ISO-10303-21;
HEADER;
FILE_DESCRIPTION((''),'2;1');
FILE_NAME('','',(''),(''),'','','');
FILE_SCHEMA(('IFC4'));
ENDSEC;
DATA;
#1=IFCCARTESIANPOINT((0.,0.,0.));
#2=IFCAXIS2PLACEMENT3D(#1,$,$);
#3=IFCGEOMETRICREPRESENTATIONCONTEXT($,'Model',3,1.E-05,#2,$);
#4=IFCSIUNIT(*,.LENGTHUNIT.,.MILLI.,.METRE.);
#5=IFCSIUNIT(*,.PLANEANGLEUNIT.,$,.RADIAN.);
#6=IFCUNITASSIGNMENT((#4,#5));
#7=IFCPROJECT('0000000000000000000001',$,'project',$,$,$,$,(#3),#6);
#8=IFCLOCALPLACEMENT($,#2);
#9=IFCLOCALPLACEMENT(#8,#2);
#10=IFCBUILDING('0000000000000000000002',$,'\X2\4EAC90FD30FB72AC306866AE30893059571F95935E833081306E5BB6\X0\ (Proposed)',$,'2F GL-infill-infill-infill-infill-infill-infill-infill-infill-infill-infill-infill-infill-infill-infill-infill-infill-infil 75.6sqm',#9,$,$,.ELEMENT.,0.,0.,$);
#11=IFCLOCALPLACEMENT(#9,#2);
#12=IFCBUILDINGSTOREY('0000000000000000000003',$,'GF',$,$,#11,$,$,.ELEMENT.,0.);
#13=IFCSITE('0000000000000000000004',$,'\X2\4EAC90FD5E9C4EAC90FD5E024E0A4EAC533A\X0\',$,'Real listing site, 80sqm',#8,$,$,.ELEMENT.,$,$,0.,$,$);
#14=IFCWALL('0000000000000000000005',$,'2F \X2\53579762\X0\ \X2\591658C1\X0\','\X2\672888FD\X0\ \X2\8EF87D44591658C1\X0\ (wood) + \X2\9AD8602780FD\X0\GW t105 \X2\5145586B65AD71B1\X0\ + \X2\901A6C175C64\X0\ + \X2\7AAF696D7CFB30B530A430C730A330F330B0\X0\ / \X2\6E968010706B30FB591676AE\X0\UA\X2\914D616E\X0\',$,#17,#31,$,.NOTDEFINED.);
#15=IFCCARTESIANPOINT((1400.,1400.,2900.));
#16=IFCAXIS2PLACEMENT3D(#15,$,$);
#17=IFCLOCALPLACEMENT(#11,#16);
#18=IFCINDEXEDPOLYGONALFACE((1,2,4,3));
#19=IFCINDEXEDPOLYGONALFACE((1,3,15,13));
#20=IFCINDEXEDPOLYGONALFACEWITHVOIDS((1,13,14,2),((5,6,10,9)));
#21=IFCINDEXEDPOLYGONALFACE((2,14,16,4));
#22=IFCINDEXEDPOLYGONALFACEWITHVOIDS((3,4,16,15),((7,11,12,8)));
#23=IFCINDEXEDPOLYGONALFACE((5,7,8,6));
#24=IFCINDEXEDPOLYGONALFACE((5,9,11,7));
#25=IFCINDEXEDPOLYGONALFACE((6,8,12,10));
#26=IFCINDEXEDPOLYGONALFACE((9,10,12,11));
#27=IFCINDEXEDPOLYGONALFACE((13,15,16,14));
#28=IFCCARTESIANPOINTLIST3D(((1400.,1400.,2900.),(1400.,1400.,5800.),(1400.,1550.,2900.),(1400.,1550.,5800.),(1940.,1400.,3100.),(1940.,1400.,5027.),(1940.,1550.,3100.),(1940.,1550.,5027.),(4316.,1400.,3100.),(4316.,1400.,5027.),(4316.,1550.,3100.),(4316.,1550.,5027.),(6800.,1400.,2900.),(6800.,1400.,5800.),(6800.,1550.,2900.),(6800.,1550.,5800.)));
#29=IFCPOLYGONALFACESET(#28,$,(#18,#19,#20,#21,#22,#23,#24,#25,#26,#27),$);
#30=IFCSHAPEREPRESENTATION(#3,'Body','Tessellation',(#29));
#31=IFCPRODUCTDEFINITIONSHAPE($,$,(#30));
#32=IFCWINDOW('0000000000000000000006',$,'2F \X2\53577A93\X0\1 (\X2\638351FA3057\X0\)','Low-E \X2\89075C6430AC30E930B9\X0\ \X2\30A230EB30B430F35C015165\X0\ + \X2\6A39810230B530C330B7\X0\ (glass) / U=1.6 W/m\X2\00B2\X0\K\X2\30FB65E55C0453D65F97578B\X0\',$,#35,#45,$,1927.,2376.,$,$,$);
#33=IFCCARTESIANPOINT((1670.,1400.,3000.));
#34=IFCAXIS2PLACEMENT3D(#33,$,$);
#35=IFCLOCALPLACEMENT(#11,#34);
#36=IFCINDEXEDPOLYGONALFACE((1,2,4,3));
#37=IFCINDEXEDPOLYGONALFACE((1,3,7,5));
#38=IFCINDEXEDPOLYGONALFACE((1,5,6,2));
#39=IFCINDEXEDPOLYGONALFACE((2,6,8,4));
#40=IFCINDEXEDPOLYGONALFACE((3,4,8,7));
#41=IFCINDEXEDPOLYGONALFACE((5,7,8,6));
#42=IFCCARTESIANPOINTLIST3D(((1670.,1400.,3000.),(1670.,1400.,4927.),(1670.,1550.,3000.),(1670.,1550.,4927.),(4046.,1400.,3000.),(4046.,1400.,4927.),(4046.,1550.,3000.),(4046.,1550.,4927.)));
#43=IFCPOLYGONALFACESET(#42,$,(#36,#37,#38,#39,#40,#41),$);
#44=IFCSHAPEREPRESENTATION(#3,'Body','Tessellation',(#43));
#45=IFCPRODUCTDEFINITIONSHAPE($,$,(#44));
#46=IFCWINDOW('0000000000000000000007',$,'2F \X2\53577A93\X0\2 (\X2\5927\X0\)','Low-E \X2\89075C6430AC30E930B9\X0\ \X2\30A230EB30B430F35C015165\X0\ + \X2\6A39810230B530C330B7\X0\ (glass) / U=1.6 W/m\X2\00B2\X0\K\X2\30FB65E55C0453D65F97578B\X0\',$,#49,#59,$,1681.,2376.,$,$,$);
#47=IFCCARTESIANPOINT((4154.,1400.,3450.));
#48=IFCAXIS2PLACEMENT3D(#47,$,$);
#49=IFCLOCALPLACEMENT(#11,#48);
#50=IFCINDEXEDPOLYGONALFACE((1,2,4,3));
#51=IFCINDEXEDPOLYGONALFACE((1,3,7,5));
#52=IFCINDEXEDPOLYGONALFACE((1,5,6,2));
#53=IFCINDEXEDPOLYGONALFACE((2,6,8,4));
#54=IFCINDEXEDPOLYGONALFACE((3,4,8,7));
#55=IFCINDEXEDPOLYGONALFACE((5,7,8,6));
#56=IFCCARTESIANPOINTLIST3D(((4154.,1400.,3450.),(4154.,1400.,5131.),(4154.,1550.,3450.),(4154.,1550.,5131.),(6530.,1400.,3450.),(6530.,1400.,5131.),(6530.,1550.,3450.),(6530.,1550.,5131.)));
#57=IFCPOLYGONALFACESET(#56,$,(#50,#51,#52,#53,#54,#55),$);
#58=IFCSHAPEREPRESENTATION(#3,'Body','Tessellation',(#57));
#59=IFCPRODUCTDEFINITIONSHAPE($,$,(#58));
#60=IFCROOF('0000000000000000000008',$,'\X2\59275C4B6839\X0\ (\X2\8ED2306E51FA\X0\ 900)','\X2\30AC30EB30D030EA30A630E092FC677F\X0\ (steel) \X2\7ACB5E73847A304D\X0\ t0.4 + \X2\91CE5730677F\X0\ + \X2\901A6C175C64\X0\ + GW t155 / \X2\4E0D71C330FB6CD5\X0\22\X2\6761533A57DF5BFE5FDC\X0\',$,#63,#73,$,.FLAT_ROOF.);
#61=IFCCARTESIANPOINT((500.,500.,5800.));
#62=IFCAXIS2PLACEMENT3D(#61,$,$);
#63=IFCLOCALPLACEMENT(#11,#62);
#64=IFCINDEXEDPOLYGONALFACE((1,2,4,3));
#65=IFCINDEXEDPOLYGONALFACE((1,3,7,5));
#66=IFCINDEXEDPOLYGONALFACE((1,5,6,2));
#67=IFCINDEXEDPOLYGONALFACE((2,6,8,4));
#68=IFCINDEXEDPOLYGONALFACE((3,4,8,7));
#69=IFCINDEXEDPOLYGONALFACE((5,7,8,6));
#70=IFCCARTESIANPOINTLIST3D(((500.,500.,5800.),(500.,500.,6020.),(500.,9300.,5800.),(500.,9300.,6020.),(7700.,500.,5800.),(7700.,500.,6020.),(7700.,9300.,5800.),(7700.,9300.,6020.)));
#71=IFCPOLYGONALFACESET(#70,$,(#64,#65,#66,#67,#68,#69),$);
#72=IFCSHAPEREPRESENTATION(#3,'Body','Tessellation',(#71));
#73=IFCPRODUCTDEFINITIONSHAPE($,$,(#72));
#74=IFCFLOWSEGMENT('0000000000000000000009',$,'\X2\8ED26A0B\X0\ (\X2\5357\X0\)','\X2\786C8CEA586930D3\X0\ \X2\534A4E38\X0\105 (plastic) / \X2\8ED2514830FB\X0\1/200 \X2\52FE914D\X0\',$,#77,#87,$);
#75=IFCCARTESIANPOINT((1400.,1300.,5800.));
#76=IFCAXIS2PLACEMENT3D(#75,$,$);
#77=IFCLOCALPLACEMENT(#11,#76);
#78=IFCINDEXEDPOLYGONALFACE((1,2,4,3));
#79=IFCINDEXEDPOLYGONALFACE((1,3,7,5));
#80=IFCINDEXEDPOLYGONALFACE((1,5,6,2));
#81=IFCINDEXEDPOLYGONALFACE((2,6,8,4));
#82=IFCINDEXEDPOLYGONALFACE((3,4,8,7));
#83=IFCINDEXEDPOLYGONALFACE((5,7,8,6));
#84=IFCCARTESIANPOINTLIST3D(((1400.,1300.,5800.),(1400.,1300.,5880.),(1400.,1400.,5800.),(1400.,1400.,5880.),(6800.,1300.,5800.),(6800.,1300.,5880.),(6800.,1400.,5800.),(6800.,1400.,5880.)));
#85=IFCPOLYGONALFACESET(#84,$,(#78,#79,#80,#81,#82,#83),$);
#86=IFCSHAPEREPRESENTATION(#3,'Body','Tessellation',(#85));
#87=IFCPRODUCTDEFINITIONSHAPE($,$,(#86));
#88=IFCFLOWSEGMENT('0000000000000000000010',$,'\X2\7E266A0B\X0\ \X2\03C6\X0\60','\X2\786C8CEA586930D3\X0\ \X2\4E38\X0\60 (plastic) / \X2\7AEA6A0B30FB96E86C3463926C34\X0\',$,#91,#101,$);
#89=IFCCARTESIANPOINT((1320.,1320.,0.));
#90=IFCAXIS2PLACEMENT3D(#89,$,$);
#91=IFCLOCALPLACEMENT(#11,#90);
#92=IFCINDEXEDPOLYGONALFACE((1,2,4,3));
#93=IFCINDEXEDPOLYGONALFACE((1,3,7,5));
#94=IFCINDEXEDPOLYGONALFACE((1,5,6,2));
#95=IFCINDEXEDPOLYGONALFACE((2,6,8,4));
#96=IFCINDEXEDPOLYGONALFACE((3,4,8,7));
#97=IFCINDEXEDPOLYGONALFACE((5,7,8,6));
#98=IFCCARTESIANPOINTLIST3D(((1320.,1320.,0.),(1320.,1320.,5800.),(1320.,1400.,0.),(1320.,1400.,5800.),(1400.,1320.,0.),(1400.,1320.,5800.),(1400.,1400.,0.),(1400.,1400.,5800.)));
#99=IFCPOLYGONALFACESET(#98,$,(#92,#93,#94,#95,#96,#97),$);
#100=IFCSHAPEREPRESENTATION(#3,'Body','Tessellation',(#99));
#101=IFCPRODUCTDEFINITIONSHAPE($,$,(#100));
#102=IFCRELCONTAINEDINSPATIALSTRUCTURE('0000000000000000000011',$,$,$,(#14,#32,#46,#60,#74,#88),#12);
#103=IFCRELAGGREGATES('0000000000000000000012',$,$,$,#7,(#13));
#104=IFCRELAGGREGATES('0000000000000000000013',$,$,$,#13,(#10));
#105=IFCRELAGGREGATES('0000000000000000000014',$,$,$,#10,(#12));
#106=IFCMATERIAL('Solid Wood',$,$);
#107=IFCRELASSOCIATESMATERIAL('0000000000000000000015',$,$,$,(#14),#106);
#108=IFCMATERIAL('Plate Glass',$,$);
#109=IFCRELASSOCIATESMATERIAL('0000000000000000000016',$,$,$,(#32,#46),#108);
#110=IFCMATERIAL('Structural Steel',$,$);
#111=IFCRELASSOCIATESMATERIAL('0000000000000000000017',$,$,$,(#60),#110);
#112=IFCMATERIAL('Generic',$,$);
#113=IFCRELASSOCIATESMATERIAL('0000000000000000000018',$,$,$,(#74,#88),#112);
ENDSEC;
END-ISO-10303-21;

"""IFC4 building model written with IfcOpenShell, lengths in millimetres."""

from ifc_helpers import new_model, si_unit, frame, frame_2d, origin, place, context, project, spatial, rectangle, extrude, material, element, fill, save


model = new_model("IFC4")

# Units and contexts
model_context = context("Model", 3, precision=1e-05, world=origin())
ifc_project = project(units=[si_unit("LENGTHUNIT", "METRE", prefix="MILLI"), si_unit("PLANEANGLEUNIT", "RADIAN")], contexts=[model_context])

# Site, building, storey
site_placement = place(None, origin())
site = spatial("IfcSite", under=ifc_project, at=site_placement, Name="京都府京都市上京区", ObjectType="Real listing site, 80sqm", CompositionType="ELEMENT", RefElevation=0.0)
building_placement = place(site_placement, origin())
building = spatial("IfcBuilding", under=site, at=building_placement, Name="京都・犬と暮らす土間広めの家 (Proposed)", ObjectType="2F GL-infill-infill-infill-infill-infill-infill-infill-infill-infill-infill-infill-infill-infill-infill-infill-infill-infil 75.6sqm", CompositionType="ELEMENT", ElevationOfRefHeight=0.0, ElevationOfTerrain=0.0)
storey_placement = place(building_placement, origin())
storey = spatial("IfcBuildingStorey", under=building, at=storey_placement, Name="GF", CompositionType="ELEMENT", Elevation=0.0)

# Shared definitions
ifc_material_1 = material(Name="Solid Wood")

# Shared definitions
ifc_material_2 = material(Name="Plate Glass")

# Wall, openings, windows
wall_1_placement = place(storey_placement, frame((1400.0, 1400.0, 2900.0)))
wall_1 = element("IfcWall", 1, at=wall_1_placement, inside=storey, material=ifc_material_1, Name="2F 南面 外壁", Description="木製 軸組外壁 (wood) + 高性能GW t105 充填断熱 + 通気層 + 窯業系サイディング / 準耐火・外皮UA配慮", PredefinedType="NOTDEFINED", context=model_context, shape_type="SweptSolid", body=[
    extrude(rectangle(XDim=5400.0, YDim=150.0, at=frame_2d((2700.0, 75.0))), frame((1400.0, 1400.0, 2900.0)), (0.0, 0.0, 1.0), 2900.0),
])
opening_1_placement = place(storey_placement, frame((1670.0, 1400.0, 3000.0)))
opening_1 = element("IfcOpeningElement", 2, at=opening_1_placement, cuts=wall_1, PredefinedType="NOTDEFINED", context=model_context, shape_type="SweptSolid", body=[
    extrude(rectangle(XDim=2376.0, YDim=150.0, at=frame_2d((1188.0, 75.0))), frame((1670.0, 1400.0, 3000.0)), (0.0, 0.0, 1.0), 1927.0),
])
opening_2_placement = place(storey_placement, frame((4154.0, 1400.0, 3450.0)))
opening_2 = element("IfcOpeningElement", 3, at=opening_2_placement, cuts=wall_1, PredefinedType="NOTDEFINED", context=model_context, shape_type="SweptSolid", body=[
    extrude(rectangle(XDim=2376.0, YDim=150.0, at=frame_2d((1188.0, 75.0))), frame((4154.0, 1400.0, 3450.0)), (0.0, 0.0, 1.0), 1681.0),
])
window_1_placement = place(storey_placement, frame((1670.0, 1400.0, 3000.0)))
window_1 = element("IfcWindow", 4, at=window_1_placement, inside=storey, material=ifc_material_2, Name="2F 南窓1 (掃出し)", Description="Low-E 複層ガラス アルゴン封入 + 樹脂サッシ (glass) / U=1.6 W/m²K・日射取得型", OverallHeight=1927.0, OverallWidth=2376.0, context=model_context, shape_type="SweptSolid", body=[
    extrude(rectangle(XDim=2376.0, YDim=150.0, at=frame_2d((1188.0, 75.0))), frame((1670.0, 1400.0, 3000.0)), (0.0, 0.0, 1.0), 1927.0),
])
fill(opening_1, window_1)
window_2_placement = place(storey_placement, frame((4154.0, 1400.0, 3450.0)))
window_2 = element("IfcWindow", 5, at=window_2_placement, inside=storey, material=ifc_material_2, Name="2F 南窓2 (大)", Description="Low-E 複層ガラス アルゴン封入 + 樹脂サッシ (glass) / U=1.6 W/m²K・日射取得型", OverallHeight=1681.0, OverallWidth=2376.0, context=model_context, shape_type="SweptSolid", body=[
    extrude(rectangle(XDim=2376.0, YDim=150.0, at=frame_2d((1188.0, 75.0))), frame((4154.0, 1400.0, 3450.0)), (0.0, 0.0, 1.0), 1681.0),
])
fill(opening_2, window_2)

# Roof
ifc_material_3 = material(Name="Structural Steel")
roof_placement = place(storey_placement, frame((500.0, 500.0, 5800.0)))
element("IfcRoof", 6, at=roof_placement, inside=storey, material=ifc_material_3, Name="大屋根 (軒の出 900)", Description="ガルバリウム鋼板 (steel) 立平葺き t0.4 + 野地板 + 通気層 + GW t155 / 不燃・法22条区域対応", PredefinedType="FLAT_ROOF", context=model_context, shape_type="SweptSolid", body=[
    extrude(rectangle(XDim=7200.0, YDim=8800.0, at=frame_2d((3600.0, 4400.0))), frame((500.0, 500.0, 5800.0)), (0.0, 0.0, 1.0), 220.0),
])

# Flow segments
ifc_material_4 = material(Name="Generic")
flow_segment_1_placement = place(storey_placement, frame((1400.0, 1300.0, 5800.0)))
element("IfcFlowSegment", 7, at=flow_segment_1_placement, inside=storey, material=ifc_material_4, Name="軒樋 (南)", Description="硬質塩ビ 半丸105 (plastic) / 軒先・1/200 勾配", context=model_context, shape_type="SweptSolid", body=[
    extrude(rectangle(XDim=5400.0, YDim=100.0, at=frame_2d((2700.0, 50.0))), frame((1400.0, 1300.0, 5800.0)), (0.0, 0.0, 1.0), 80.0),
])
flow_segment_2_placement = place(storey_placement, frame((1320.0, 1320.0, 0.0)))
element("IfcFlowSegment", 8, at=flow_segment_2_placement, inside=storey, material=ifc_material_4, Name="縦樋 φ60", Description="硬質塩ビ 丸60 (plastic) / 竪樋・雨水排水", context=model_context, shape_type="SweptSolid", body=[
    extrude(rectangle(XDim=80.0, YDim=80.0, at=frame_2d((40.0, 40.0))), frame((1320.0, 1320.0, 0.0)), (0.0, 0.0, 1.0), 5800.0),
])

save(model, "model.ifc")
